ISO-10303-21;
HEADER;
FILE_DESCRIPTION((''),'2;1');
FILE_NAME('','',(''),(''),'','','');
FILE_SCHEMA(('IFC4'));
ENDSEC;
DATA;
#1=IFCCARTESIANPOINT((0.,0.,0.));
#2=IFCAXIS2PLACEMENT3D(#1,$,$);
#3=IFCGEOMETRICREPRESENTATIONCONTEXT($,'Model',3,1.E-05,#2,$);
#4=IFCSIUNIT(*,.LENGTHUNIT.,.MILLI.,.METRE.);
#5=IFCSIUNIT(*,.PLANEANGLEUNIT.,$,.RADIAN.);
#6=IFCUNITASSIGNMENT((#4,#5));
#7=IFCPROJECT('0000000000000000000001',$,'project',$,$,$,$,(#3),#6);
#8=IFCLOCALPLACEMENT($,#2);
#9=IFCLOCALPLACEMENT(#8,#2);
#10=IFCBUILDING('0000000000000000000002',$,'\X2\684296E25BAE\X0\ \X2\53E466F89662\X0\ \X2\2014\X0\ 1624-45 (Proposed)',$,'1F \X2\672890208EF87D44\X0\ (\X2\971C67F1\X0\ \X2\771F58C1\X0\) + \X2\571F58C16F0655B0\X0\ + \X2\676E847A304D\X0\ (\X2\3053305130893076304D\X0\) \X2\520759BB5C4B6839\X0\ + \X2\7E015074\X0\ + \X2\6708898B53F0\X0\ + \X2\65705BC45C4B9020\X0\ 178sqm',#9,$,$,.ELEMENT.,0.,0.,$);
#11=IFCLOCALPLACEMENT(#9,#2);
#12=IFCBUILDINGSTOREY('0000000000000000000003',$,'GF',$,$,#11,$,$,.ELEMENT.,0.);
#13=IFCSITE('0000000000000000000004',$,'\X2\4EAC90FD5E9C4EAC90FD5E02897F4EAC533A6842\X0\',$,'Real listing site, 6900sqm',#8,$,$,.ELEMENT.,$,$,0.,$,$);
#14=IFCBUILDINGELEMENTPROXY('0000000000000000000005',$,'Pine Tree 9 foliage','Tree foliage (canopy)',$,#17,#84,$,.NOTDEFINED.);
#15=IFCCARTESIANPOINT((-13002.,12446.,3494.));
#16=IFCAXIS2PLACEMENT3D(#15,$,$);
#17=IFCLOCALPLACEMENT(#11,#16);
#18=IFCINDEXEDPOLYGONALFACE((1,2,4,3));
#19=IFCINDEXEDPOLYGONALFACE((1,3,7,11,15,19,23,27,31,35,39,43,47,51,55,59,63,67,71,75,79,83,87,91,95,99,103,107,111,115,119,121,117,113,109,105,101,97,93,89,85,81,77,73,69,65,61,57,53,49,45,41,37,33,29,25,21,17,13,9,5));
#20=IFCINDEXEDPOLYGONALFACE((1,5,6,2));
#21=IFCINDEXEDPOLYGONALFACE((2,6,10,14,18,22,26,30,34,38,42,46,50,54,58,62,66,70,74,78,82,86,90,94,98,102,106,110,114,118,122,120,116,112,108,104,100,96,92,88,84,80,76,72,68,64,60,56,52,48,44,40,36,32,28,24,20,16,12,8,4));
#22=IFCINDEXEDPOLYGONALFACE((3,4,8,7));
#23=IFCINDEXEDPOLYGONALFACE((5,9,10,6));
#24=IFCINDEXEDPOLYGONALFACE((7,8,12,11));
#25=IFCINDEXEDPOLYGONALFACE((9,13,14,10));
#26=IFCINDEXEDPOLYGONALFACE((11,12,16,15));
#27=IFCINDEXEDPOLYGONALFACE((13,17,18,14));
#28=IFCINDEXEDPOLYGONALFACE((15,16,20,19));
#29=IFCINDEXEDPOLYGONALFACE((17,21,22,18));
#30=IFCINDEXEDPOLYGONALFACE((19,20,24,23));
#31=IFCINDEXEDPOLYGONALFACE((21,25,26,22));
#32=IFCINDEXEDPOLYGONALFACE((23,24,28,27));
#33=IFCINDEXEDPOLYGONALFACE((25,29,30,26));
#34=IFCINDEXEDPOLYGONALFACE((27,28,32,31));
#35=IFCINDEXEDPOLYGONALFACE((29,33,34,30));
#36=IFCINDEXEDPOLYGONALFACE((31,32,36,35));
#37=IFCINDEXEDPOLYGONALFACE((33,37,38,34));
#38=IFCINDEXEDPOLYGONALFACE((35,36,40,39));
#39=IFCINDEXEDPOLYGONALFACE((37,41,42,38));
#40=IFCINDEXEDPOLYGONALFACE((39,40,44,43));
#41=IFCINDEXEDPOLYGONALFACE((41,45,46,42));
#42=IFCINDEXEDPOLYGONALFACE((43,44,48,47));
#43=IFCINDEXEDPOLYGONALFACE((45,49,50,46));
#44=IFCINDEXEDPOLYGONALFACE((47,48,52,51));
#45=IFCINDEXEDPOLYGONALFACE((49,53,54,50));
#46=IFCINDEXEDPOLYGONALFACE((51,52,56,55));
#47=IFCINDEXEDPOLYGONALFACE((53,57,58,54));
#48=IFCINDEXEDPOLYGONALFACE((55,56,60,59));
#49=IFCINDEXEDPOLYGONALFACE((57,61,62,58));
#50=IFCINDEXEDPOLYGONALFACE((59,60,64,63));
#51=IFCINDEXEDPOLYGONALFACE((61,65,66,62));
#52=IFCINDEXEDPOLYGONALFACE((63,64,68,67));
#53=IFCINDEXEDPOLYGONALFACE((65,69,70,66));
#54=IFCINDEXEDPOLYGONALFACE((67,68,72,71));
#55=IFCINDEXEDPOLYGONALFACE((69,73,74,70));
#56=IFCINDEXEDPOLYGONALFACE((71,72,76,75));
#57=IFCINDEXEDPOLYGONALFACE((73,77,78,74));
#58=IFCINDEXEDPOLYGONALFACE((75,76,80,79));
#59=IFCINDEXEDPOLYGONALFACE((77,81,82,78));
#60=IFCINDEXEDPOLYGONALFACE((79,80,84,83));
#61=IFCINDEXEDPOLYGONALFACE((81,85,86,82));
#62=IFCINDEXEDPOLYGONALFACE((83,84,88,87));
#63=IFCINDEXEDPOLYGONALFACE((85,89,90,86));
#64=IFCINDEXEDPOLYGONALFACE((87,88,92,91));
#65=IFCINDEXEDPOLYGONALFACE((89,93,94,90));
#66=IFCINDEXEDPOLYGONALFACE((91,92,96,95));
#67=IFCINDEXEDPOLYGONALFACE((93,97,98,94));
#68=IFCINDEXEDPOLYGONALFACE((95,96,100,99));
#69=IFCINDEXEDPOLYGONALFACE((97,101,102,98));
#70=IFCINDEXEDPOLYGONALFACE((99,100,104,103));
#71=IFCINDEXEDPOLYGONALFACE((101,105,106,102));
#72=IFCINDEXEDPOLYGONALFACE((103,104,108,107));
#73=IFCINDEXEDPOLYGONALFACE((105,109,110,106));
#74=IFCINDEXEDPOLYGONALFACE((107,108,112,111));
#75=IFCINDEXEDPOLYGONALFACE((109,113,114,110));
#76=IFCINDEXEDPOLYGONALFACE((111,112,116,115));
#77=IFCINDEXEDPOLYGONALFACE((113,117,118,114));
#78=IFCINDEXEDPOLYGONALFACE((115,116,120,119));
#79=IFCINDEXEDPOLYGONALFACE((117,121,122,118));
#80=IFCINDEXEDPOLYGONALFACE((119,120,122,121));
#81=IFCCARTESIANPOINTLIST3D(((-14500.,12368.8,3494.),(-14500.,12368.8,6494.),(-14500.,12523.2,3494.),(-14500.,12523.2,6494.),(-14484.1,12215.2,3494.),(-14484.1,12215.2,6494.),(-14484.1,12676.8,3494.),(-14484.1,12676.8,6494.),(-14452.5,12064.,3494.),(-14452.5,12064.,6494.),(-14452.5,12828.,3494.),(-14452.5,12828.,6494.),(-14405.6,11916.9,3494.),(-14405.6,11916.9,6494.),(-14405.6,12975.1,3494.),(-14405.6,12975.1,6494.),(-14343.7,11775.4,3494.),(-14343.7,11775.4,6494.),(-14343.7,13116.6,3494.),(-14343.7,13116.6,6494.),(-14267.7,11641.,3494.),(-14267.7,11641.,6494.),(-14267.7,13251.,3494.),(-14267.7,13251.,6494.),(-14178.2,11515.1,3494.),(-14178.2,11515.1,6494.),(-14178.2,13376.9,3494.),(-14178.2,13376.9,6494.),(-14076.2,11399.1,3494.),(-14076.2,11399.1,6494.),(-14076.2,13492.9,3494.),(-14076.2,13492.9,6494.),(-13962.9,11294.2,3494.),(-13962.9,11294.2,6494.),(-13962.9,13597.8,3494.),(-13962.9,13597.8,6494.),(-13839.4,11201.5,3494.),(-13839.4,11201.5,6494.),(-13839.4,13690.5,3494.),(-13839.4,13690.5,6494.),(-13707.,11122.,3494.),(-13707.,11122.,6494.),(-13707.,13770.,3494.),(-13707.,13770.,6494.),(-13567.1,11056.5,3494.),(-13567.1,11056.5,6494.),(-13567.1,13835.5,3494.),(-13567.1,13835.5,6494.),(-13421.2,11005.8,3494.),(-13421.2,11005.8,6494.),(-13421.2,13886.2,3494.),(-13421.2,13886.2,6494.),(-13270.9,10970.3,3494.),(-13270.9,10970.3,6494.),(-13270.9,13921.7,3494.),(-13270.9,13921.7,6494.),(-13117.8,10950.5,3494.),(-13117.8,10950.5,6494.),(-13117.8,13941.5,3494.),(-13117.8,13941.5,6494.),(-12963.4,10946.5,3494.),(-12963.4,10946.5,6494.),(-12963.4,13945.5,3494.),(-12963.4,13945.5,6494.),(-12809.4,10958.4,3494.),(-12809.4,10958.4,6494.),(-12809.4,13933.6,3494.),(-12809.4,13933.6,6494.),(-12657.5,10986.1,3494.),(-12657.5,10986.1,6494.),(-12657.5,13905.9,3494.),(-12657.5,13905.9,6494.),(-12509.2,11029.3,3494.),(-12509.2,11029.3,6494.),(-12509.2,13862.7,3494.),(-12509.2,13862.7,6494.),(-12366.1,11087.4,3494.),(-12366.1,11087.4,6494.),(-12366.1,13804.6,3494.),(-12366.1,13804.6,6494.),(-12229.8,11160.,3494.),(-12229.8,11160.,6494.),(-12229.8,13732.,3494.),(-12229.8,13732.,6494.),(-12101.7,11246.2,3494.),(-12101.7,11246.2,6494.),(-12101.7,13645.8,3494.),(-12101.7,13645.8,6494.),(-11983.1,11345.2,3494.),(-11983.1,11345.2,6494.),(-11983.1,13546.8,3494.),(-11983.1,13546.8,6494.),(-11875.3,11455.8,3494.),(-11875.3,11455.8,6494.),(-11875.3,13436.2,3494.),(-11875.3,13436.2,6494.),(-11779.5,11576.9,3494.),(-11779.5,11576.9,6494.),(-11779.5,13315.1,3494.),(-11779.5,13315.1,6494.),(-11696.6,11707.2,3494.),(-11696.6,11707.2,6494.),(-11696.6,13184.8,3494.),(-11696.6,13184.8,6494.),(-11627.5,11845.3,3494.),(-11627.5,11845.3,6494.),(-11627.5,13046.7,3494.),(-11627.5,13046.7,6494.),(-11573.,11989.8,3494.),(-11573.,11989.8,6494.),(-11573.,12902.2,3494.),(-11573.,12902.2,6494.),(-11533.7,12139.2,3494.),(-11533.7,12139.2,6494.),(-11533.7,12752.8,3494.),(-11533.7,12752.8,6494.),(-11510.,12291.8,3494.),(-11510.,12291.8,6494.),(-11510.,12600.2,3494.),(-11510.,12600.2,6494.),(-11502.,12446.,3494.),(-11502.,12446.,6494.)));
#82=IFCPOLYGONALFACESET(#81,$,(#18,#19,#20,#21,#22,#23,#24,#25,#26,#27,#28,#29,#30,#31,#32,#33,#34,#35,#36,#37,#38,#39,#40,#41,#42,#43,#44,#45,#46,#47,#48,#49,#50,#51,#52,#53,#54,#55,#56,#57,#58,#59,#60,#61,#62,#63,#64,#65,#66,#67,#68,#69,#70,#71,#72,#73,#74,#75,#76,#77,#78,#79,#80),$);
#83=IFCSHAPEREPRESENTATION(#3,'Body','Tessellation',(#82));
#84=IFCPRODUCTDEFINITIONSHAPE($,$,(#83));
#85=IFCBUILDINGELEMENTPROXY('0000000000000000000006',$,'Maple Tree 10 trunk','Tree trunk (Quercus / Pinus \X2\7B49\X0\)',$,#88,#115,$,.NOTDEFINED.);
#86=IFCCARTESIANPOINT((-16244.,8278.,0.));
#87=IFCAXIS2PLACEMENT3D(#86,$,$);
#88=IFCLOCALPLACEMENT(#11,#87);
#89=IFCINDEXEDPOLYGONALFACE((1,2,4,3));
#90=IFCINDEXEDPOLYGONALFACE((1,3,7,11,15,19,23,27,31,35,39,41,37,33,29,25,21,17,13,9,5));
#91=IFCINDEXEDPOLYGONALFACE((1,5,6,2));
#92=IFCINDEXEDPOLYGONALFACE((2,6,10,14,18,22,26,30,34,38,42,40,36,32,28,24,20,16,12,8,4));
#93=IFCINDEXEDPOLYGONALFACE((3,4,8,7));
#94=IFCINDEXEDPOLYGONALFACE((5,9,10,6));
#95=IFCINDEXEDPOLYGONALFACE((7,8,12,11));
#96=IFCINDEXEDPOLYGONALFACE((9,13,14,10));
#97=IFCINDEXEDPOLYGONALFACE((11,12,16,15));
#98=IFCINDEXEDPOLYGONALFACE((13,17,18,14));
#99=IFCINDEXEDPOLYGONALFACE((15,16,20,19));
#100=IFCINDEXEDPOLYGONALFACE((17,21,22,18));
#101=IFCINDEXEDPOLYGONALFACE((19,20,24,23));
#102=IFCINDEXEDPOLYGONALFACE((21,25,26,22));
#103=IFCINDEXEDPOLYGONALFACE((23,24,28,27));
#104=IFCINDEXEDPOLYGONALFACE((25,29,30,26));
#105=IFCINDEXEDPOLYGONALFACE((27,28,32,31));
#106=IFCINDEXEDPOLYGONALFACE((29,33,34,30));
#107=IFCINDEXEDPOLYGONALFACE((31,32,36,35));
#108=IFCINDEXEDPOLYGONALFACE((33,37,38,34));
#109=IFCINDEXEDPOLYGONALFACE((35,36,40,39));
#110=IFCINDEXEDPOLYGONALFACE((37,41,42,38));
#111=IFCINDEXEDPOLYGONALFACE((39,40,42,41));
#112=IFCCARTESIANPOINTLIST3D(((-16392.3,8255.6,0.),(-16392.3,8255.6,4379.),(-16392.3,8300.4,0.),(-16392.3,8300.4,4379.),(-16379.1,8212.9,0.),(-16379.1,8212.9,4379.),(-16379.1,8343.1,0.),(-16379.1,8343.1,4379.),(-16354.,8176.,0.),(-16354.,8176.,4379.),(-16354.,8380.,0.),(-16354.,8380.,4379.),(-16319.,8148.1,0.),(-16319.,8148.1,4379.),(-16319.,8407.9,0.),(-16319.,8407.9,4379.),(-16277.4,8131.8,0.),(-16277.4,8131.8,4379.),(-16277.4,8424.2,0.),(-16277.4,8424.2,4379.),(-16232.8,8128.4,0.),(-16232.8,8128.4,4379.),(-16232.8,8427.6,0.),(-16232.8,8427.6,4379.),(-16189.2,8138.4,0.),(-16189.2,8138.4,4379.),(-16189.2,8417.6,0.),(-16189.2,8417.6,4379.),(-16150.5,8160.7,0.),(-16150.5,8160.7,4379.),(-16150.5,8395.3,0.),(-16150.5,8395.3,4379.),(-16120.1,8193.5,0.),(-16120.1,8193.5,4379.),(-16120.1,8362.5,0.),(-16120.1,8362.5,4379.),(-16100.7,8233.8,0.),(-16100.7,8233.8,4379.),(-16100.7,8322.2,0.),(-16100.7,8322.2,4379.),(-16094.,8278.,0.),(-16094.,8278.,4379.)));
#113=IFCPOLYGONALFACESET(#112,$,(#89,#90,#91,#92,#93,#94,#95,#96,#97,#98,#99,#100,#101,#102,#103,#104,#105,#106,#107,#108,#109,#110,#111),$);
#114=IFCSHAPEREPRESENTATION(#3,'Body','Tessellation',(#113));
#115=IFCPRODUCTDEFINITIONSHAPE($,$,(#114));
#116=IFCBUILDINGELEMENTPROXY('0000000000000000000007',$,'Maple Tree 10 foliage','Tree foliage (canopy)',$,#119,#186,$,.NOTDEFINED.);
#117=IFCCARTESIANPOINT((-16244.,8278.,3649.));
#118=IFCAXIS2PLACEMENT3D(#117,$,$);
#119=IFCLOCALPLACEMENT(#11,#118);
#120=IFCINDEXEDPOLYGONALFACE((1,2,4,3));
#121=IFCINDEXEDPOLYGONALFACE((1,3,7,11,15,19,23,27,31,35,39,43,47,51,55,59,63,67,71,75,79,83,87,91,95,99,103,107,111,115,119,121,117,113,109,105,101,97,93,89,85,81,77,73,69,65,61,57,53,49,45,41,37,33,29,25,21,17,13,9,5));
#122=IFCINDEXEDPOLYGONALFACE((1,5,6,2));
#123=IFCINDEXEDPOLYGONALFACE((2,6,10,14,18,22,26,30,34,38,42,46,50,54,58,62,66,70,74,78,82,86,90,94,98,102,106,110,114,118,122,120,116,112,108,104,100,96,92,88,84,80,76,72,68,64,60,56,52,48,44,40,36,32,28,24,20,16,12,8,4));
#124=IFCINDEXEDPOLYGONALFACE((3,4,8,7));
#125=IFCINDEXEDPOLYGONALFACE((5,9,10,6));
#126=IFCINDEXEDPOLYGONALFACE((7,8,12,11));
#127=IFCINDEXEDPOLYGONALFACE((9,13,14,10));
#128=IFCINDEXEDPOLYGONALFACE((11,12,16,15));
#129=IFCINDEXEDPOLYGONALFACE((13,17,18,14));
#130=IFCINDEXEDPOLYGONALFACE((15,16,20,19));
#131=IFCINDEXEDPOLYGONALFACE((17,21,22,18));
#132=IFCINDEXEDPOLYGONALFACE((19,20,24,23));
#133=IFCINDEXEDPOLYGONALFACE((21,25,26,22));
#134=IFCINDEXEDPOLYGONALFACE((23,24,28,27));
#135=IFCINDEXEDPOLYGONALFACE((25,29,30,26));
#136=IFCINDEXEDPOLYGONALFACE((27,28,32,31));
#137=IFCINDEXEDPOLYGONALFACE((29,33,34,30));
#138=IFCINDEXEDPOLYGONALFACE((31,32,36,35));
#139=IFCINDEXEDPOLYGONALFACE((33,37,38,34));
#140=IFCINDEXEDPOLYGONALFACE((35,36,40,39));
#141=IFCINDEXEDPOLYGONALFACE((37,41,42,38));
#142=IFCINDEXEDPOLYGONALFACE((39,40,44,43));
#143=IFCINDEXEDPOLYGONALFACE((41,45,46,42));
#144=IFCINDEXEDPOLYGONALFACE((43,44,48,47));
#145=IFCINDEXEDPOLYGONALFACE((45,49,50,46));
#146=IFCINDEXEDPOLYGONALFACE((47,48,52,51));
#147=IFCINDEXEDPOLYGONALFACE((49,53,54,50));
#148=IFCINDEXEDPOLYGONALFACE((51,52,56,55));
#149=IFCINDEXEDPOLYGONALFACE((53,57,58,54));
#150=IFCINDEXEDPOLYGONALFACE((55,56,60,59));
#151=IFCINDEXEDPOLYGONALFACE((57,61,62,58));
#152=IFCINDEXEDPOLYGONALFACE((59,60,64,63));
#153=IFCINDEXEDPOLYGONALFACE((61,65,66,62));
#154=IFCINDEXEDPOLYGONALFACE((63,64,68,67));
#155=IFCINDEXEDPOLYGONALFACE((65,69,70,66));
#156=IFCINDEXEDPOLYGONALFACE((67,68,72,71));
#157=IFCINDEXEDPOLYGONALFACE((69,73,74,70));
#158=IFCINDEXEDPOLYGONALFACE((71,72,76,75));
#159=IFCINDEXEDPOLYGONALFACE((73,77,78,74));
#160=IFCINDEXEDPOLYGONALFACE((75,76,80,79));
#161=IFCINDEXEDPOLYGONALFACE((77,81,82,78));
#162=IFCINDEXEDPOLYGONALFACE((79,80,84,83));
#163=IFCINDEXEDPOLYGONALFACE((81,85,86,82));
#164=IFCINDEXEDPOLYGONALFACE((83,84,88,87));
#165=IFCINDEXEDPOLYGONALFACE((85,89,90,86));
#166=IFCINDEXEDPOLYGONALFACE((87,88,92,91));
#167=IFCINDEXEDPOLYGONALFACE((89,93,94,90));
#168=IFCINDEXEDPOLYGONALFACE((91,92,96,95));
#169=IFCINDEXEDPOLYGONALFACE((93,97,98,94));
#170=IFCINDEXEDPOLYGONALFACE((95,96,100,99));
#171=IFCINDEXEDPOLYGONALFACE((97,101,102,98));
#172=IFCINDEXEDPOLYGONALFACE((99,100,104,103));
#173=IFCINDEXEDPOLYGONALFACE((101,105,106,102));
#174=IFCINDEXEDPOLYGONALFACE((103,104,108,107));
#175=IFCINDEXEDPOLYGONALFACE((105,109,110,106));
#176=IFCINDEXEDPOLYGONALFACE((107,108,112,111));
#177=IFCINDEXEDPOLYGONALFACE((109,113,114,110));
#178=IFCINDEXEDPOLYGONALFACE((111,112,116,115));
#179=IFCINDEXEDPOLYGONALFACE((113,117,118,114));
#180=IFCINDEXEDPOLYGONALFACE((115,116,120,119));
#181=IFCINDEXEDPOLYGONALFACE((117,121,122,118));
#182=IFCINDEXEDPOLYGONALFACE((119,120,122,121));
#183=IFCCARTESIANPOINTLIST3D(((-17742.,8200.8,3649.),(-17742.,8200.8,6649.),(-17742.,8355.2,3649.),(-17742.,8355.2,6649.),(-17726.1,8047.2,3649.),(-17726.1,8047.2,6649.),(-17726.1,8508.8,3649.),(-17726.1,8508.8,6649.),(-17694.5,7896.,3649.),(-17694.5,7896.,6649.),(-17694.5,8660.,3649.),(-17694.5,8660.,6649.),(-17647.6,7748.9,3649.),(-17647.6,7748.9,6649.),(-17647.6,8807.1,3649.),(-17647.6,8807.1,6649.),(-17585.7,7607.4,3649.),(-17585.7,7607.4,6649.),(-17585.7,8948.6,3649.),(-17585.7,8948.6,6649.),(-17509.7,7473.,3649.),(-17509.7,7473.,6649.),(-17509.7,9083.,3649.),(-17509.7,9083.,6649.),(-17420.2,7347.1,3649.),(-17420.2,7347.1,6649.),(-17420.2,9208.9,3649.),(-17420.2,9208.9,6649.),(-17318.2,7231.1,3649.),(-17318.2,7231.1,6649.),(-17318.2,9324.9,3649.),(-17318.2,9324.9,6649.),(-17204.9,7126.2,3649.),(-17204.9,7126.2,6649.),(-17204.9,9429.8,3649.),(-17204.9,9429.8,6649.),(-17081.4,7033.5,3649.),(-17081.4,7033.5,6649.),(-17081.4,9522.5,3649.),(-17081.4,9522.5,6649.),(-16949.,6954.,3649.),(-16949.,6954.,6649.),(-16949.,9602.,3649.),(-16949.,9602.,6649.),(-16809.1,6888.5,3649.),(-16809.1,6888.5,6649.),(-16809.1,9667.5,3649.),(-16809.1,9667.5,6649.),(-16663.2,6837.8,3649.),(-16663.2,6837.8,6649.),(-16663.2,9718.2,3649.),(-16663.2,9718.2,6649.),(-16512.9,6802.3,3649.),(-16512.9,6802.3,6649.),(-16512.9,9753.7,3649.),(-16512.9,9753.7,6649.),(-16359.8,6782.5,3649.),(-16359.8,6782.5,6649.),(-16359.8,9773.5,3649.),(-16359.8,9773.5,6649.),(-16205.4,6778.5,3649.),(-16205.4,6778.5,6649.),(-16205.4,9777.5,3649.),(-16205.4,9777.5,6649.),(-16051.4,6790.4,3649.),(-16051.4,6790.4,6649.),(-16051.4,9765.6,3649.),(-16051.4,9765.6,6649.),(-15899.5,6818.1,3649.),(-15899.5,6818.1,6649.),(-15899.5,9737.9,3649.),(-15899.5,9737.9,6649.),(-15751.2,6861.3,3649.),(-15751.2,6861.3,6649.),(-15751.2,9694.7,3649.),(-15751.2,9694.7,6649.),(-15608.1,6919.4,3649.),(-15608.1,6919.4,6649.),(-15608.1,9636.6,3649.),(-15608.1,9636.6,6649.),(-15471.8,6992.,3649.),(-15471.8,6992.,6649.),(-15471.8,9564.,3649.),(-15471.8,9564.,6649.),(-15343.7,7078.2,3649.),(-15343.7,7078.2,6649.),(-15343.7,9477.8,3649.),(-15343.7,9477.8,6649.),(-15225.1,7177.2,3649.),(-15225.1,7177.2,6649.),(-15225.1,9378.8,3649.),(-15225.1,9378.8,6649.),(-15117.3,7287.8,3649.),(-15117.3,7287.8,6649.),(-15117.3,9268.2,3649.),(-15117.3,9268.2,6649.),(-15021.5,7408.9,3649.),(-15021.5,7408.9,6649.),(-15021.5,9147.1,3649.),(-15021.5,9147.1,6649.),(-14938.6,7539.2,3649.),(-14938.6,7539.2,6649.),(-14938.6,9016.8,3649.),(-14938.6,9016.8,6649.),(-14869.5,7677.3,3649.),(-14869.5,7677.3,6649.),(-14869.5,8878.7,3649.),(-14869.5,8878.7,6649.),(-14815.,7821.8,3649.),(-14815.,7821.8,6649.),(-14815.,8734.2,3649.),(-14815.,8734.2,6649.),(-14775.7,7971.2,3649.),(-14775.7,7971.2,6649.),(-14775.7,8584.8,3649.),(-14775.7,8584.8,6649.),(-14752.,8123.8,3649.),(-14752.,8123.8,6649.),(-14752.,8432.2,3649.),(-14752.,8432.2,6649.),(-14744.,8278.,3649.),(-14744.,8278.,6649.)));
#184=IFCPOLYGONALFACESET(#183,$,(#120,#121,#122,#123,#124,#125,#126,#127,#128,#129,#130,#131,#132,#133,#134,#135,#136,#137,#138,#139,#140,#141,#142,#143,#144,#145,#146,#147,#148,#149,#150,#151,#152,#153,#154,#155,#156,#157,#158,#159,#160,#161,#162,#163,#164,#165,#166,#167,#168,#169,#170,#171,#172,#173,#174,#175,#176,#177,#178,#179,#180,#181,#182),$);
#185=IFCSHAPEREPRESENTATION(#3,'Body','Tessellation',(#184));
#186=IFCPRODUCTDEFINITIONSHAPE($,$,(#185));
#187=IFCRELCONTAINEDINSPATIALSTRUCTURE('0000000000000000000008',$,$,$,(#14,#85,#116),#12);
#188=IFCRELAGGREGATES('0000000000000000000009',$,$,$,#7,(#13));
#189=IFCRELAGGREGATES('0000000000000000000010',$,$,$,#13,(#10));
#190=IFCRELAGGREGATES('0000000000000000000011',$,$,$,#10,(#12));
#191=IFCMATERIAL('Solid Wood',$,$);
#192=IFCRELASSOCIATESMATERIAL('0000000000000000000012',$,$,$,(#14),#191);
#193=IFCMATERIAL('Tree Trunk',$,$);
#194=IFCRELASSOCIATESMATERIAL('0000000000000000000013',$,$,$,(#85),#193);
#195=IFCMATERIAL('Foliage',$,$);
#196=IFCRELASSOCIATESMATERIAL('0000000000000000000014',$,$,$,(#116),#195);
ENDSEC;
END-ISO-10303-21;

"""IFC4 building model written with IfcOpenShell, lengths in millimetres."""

from ifc_helpers import new_model, si_unit, frame, origin, origin_2d, place, context, project, spatial, circle, extrude, material, element, save


model = new_model("IFC4")

# Units and contexts
model_context = context("Model", 3, precision=1e-05, world=origin())
ifc_project = project(units=[si_unit("LENGTHUNIT", "METRE", prefix="MILLI"), si_unit("PLANEANGLEUNIT", "RADIAN")], contexts=[model_context])

# Site, building, storey
site_placement = place(None, origin())
site = spatial("IfcSite", under=ifc_project, at=site_placement, Name="京都府京都市西京区桂", ObjectType="Real listing site, 6900sqm", CompositionType="ELEMENT", RefElevation=0.0)
building_placement = place(site_placement, origin())
building = spatial("IfcBuilding", under=site, at=building_placement, Name="桂離宮 古書院 — 1624-45 (Proposed)", ObjectType="1F 木造軸組 (霜柱 真壁) + 土壁漆喰 + 杮葺き (こけらぶき) 切妻屋根 + 縁側 + 月見台 + 数寄屋造 178sqm", CompositionType="ELEMENT", ElevationOfRefHeight=0.0, ElevationOfTerrain=0.0)
storey_placement = place(building_placement, origin())
storey = spatial("IfcBuildingStorey", under=building, at=storey_placement, Name="GF", CompositionType="ELEMENT", Elevation=0.0)

# Shared definitions
ifc_material_1 = material(Name="Solid Wood")

# Building element proxies
ifc_material_2 = material(Name="Foliage")
proxy_1_placement = place(storey_placement, frame((-13002.0, 12446.0, 3494.0)))
element("IfcBuildingElementProxy", 1, at=proxy_1_placement, inside=storey, material=ifc_material_1, Name="Pine Tree 9 foliage", Description="Tree foliage (canopy)", PredefinedType="NOTDEFINED", context=model_context, shape_type="SweptSolid", body=[
    extrude(circle(Radius=1500.0, at=origin_2d()), frame((-13002.0, 12446.0, 3494.0)), (0.0, 0.0, 1.0), 3000.0),
])
ifc_material_3 = material(Name="Tree Trunk")
proxy_2_placement = place(storey_placement, frame((-16244.0, 8278.0, 0.0)))
element("IfcBuildingElementProxy", 2, at=proxy_2_placement, inside=storey, material=ifc_material_3, Name="Maple Tree 10 trunk", Description="Tree trunk (Quercus / Pinus 等)", PredefinedType="NOTDEFINED", context=model_context, shape_type="SweptSolid", body=[
    extrude(circle(Radius=150.0, at=origin_2d()), frame((-16244.0, 8278.0, 0.0)), (0.0, 0.0, 1.0), 4379.0),
])
proxy_3_placement = place(storey_placement, frame((-16244.0, 8278.0, 3649.0)))
element("IfcBuildingElementProxy", 3, at=proxy_3_placement, inside=storey, material=ifc_material_2, Name="Maple Tree 10 foliage", Description="Tree foliage (canopy)", PredefinedType="NOTDEFINED", context=model_context, shape_type="SweptSolid", body=[
    extrude(circle(Radius=1500.0, at=origin_2d()), frame((-16244.0, 8278.0, 3649.0)), (0.0, 0.0, 1.0), 3000.0),
])

save(model, "model.ifc")
